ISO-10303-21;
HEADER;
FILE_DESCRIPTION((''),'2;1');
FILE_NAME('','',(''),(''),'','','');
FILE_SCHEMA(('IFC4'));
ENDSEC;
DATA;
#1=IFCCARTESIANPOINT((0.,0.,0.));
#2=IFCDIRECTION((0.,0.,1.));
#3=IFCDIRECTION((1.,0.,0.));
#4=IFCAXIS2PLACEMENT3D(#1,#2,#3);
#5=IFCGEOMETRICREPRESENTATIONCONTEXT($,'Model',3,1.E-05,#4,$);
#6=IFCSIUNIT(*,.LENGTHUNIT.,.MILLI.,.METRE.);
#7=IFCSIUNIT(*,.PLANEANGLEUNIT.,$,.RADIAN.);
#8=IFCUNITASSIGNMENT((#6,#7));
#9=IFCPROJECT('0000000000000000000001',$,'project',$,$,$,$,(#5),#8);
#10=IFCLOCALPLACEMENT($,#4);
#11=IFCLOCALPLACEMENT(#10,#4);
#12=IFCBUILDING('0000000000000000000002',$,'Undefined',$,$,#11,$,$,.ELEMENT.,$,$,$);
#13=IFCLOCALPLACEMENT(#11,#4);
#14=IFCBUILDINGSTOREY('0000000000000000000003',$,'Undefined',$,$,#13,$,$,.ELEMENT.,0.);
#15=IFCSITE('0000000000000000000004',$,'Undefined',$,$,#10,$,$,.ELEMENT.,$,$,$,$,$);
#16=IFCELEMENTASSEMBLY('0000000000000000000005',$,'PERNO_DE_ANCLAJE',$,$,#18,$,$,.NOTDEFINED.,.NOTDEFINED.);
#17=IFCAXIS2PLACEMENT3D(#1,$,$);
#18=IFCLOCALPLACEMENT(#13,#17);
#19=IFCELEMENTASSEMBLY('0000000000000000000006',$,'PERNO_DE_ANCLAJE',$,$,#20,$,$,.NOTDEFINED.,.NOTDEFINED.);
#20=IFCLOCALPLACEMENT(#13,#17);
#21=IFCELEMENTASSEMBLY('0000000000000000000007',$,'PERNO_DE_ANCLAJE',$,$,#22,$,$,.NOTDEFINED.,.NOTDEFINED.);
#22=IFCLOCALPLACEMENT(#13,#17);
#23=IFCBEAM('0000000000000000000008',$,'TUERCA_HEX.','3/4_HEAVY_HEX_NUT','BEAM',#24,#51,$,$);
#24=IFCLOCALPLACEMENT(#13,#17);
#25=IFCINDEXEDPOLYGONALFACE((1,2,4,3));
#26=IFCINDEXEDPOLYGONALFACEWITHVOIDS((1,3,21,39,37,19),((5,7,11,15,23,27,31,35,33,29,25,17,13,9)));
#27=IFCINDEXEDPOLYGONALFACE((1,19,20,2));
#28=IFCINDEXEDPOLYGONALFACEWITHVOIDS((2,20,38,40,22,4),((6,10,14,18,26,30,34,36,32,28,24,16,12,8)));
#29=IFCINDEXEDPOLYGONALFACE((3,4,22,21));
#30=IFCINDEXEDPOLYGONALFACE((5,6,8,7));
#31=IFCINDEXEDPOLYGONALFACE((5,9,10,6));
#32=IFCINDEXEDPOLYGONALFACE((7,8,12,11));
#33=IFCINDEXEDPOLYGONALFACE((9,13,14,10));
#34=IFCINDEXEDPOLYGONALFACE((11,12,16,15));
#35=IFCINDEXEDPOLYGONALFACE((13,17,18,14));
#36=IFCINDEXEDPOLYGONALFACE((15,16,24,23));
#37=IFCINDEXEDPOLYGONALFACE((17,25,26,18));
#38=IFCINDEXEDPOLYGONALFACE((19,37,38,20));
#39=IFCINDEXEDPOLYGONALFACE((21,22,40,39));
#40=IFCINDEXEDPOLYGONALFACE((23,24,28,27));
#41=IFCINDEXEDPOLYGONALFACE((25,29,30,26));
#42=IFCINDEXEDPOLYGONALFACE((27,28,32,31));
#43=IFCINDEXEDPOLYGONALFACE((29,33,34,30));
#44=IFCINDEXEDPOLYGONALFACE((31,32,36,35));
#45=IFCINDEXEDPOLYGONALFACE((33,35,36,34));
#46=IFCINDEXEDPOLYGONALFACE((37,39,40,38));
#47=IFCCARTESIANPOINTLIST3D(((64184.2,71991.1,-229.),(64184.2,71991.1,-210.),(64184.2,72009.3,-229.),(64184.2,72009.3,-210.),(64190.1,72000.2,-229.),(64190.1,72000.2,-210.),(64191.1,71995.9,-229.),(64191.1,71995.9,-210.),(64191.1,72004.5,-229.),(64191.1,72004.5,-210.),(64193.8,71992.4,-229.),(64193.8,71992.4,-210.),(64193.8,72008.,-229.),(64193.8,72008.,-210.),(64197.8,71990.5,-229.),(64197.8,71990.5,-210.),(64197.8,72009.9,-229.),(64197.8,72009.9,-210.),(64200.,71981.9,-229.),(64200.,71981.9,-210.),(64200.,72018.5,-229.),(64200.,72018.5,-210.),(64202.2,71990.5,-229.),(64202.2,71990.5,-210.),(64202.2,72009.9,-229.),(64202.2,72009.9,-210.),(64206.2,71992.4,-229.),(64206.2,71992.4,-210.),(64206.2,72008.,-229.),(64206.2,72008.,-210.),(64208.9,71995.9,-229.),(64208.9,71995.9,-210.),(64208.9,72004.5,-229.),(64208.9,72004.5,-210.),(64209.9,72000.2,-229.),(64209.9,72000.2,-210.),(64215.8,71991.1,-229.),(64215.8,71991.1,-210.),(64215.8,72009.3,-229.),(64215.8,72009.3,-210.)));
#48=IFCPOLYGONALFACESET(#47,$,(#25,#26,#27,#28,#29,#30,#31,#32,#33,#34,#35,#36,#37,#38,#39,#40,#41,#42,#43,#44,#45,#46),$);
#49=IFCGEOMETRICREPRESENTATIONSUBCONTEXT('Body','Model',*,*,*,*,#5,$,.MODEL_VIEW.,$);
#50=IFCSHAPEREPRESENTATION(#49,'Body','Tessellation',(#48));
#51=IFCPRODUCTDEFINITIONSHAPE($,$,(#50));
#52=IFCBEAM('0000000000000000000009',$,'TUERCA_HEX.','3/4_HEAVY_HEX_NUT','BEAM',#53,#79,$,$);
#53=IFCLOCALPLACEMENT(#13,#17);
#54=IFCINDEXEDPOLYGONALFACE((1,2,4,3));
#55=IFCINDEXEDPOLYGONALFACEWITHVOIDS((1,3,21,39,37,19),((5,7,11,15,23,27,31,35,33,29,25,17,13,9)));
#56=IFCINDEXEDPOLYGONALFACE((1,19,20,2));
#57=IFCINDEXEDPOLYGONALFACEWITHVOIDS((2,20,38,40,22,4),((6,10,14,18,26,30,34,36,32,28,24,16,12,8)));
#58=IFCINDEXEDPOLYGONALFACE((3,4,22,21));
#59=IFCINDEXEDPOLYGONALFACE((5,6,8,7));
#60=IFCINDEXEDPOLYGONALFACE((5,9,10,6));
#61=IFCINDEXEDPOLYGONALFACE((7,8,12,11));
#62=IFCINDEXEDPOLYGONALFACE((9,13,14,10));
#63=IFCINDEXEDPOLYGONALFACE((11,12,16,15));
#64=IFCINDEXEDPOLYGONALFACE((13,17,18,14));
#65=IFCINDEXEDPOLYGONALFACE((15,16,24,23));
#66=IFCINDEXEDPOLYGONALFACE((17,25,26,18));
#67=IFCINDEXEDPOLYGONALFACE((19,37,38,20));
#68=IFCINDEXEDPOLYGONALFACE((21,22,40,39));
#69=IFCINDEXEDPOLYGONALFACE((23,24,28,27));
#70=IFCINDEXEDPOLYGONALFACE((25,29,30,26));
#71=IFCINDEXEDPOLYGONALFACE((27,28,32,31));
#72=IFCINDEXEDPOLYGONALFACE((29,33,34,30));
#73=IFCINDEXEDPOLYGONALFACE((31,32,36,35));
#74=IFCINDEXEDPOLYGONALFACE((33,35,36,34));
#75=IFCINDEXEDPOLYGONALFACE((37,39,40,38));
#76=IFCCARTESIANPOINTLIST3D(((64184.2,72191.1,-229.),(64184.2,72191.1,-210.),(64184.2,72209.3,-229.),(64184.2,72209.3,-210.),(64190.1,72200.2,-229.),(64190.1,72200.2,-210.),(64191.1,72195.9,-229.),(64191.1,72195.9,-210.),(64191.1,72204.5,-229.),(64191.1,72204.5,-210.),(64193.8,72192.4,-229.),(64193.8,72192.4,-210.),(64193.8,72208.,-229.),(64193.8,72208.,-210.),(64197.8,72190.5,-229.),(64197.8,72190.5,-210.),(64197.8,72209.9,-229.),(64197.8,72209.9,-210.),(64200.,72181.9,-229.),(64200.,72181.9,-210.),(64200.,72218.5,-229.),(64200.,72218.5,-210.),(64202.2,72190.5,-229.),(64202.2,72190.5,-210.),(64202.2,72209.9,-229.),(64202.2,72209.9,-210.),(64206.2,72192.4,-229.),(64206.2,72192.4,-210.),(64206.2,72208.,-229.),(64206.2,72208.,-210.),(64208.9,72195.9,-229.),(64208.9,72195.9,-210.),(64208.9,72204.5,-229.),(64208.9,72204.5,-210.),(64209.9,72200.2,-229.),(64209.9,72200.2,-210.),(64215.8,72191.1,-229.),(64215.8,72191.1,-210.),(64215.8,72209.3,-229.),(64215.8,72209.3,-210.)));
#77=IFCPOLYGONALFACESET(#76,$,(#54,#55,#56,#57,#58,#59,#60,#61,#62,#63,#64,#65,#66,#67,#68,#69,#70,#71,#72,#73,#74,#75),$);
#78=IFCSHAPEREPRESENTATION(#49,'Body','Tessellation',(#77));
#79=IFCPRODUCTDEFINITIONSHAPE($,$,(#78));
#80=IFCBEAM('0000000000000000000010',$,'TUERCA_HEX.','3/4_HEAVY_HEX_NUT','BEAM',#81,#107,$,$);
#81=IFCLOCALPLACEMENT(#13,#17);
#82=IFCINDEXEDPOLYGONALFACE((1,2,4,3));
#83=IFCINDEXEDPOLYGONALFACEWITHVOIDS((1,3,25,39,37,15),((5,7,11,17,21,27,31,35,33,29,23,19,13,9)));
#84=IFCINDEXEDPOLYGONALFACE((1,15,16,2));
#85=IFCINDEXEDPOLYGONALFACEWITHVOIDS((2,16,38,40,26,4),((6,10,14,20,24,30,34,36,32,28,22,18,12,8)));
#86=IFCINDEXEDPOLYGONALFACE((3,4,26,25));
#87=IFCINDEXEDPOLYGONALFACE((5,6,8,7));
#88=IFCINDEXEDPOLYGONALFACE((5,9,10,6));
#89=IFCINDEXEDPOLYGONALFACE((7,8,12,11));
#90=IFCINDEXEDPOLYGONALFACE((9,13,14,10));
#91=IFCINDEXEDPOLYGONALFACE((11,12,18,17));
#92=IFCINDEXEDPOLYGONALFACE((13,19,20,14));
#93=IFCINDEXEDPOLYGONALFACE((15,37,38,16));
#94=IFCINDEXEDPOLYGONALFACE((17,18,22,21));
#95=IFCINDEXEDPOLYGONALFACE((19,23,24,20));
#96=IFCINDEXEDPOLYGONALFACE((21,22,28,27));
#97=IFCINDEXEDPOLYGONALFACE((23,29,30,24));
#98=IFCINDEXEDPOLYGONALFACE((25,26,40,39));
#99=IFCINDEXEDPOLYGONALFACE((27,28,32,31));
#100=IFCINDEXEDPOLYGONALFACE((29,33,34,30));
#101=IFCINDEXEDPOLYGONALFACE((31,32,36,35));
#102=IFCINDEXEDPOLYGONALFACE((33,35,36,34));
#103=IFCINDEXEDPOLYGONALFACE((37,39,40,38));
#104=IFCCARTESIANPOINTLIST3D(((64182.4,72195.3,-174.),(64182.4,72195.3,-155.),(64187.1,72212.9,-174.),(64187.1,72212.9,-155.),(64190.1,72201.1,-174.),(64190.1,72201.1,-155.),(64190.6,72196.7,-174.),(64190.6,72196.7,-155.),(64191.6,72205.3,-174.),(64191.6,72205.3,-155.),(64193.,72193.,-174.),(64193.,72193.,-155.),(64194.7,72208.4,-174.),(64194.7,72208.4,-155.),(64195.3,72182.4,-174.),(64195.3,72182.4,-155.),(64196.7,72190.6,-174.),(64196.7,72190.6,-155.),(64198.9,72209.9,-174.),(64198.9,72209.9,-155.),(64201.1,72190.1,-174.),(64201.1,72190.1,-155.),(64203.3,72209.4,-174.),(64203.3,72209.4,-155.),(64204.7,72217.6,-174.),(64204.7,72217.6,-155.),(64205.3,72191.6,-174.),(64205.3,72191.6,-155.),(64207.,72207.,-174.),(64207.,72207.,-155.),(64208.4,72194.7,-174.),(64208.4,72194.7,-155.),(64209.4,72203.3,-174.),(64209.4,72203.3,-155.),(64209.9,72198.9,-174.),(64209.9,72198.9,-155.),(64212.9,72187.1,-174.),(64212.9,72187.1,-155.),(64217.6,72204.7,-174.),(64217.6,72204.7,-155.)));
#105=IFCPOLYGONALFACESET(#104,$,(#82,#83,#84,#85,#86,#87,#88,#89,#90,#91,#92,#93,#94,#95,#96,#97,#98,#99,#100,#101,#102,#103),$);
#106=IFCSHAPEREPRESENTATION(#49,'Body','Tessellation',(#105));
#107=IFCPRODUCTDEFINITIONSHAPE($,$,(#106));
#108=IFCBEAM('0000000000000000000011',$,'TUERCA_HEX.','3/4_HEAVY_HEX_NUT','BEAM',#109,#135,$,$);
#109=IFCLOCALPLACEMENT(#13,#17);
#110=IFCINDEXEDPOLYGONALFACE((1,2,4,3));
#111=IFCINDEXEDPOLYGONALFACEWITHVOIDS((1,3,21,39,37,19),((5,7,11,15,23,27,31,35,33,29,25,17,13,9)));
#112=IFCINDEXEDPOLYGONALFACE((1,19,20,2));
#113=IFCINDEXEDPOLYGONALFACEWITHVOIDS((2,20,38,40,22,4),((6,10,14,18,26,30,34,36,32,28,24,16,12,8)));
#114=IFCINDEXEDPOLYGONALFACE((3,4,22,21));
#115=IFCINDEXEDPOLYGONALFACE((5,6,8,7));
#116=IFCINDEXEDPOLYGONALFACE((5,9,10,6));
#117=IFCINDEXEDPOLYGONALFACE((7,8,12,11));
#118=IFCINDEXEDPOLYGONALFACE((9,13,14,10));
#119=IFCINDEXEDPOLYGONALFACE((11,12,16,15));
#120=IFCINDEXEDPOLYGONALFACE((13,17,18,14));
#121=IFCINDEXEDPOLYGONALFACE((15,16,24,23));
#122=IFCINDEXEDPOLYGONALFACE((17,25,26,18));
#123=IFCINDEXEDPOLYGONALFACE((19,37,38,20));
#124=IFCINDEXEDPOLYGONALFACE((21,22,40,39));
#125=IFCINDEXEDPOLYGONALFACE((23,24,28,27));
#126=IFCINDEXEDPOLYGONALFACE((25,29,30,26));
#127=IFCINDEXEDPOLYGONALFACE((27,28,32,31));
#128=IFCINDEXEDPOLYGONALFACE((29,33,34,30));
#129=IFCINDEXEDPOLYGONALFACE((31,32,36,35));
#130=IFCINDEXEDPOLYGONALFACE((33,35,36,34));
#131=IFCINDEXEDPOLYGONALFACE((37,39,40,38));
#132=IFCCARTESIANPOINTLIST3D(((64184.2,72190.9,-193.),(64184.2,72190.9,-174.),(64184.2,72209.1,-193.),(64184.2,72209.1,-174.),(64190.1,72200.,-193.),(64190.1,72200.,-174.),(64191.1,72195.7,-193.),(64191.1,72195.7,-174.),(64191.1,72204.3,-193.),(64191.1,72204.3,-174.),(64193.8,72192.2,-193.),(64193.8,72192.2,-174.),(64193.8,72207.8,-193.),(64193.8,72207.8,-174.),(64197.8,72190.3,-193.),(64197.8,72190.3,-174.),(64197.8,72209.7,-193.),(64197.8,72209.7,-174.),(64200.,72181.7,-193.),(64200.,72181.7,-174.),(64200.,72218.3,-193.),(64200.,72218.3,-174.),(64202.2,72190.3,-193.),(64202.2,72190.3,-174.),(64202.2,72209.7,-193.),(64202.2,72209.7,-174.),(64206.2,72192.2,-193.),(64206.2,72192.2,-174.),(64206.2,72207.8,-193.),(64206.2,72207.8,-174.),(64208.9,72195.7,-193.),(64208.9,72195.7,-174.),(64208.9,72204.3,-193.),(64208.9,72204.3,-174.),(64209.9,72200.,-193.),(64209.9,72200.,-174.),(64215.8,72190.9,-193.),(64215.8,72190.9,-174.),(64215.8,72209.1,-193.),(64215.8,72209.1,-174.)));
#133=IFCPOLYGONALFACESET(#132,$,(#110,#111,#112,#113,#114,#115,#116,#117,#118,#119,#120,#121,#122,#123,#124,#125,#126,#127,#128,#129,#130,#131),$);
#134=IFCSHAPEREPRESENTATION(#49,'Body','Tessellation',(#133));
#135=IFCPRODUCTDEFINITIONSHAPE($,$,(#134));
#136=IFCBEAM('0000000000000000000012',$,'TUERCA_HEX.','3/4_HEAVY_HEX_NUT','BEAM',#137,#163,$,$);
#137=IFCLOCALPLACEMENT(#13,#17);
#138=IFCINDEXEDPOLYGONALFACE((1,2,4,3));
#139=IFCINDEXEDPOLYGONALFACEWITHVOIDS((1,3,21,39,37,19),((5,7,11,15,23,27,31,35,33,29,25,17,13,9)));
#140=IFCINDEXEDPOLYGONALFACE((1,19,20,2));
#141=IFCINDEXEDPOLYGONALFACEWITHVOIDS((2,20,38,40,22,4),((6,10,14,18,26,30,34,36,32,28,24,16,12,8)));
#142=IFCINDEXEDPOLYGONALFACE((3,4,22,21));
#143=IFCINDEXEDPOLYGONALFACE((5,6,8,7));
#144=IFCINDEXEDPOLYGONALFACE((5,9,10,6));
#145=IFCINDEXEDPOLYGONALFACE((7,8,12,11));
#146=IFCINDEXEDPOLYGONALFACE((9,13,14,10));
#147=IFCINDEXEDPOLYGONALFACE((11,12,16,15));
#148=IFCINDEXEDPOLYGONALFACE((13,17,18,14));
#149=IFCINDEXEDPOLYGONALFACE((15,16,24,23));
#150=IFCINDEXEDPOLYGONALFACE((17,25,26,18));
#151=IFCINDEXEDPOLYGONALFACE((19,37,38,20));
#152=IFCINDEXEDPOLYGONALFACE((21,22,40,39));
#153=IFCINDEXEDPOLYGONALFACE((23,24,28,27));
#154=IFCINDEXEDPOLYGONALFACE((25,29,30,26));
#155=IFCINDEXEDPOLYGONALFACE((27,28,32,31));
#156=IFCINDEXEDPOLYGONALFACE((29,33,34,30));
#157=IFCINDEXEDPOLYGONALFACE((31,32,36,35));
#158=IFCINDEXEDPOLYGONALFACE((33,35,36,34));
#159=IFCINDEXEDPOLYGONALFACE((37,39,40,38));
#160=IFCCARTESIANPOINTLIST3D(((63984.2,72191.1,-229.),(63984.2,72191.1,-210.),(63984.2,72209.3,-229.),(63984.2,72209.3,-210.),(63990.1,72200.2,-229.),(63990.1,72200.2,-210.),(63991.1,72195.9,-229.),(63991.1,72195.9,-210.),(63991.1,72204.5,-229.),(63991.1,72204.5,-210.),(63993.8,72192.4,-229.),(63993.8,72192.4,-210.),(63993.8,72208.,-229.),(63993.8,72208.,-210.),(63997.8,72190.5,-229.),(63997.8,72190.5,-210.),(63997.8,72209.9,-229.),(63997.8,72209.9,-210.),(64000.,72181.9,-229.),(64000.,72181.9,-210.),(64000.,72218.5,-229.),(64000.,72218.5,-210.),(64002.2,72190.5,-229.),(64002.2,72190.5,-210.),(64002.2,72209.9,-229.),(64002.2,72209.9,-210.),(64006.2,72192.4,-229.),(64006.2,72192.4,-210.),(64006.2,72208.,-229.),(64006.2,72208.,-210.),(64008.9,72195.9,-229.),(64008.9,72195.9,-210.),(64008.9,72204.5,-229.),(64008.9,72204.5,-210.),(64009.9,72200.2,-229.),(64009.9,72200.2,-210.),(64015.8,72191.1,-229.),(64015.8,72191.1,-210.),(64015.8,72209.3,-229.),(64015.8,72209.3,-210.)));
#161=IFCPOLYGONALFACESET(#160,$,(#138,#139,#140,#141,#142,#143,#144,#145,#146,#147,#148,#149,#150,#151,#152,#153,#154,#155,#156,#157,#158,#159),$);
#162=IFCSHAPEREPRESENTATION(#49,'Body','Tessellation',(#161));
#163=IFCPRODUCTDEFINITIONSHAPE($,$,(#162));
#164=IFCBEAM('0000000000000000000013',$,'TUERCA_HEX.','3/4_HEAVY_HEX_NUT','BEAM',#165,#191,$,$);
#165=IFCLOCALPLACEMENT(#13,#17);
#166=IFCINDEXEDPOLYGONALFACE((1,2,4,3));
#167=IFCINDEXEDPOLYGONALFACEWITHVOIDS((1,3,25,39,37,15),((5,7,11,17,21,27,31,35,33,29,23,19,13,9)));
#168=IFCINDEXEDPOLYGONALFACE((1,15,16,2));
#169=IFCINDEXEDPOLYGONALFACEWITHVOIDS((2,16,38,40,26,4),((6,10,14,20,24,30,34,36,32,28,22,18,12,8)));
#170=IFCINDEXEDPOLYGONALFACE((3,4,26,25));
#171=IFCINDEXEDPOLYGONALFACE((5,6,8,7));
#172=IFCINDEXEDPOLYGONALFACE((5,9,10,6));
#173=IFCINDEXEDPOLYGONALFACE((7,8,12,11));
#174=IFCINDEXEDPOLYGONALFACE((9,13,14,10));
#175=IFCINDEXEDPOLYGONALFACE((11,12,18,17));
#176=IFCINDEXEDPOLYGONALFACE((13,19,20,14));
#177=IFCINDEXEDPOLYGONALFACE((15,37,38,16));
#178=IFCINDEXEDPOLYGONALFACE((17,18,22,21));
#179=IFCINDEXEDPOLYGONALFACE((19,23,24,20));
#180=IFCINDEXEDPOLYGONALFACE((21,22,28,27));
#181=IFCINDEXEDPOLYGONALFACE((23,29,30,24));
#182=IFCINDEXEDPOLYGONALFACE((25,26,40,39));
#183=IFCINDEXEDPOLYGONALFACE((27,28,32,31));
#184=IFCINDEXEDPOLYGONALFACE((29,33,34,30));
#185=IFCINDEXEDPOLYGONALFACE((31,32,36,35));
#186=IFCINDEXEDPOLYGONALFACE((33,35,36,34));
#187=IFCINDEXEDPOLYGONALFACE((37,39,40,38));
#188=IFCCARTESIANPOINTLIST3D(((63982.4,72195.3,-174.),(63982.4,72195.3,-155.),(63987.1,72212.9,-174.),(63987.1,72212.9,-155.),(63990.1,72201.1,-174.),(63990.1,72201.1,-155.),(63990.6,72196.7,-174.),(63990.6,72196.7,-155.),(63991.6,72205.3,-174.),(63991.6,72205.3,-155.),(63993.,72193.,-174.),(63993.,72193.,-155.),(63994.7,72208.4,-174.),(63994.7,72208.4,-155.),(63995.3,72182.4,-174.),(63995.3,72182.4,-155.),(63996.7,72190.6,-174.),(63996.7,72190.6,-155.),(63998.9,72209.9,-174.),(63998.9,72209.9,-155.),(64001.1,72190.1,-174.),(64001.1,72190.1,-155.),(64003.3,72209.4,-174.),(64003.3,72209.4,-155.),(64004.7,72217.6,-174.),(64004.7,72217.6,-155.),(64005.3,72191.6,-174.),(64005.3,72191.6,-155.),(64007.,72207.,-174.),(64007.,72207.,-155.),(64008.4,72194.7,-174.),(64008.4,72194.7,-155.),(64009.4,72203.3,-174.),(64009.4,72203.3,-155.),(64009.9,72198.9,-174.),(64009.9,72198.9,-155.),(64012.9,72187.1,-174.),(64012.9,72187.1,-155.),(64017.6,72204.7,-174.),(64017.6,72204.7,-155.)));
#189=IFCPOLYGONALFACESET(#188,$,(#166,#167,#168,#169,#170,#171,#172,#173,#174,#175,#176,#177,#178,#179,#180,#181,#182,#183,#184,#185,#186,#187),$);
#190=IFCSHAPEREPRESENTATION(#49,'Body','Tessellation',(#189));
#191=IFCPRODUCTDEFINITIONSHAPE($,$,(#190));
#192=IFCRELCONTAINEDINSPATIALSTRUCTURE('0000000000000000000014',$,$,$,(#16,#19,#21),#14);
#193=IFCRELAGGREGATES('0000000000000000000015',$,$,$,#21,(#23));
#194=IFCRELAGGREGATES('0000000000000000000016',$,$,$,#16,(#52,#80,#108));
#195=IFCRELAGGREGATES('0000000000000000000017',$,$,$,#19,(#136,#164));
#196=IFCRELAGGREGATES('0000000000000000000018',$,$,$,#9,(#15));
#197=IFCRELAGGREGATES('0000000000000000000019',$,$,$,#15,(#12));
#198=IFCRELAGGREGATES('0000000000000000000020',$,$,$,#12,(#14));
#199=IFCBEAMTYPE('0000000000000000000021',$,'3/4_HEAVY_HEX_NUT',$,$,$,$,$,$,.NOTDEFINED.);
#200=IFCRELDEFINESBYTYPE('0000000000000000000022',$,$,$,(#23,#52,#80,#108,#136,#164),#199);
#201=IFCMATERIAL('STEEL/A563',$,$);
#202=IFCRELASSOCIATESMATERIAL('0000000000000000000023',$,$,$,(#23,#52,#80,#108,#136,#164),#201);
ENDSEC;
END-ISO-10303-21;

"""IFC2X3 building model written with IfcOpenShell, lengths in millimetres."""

from ifc_helpers import new_model, si_unit, frame, origin_with_axes, place, context, subcontext, project, spatial, polyline, outline, extrude, material, type_object, element, aggregate, save


model = new_model("IFC2X3")

# Units and contexts
model_context = context("Model", 3, precision=1e-05, world=origin_with_axes())
body_context = subcontext(model_context, "Body", "Model", "MODEL_VIEW")
ifc_project = project(units=[si_unit("LENGTHUNIT", "METRE", prefix="MILLI"), si_unit("PLANEANGLEUNIT", "RADIAN")], contexts=[model_context])

# Site, building, storey
site_placement = place(None, origin_with_axes())
site = spatial("IfcSite", under=ifc_project, at=site_placement, Name="Undefined", CompositionType="ELEMENT")
building_placement = place(site_placement, origin_with_axes())
building = spatial("IfcBuilding", under=site, at=building_placement, Name="Undefined", CompositionType="ELEMENT")
storey_placement = place(building_placement, origin_with_axes())
storey = spatial("IfcBuildingStorey", under=building, at=storey_placement, Name="Undefined", CompositionType="ELEMENT", Elevation=0.0)

# Element assemblies, beam
assembly_1_placement = place(storey_placement, origin_with_axes())
assembly_1 = element("IfcElementAssembly", 1, at=assembly_1_placement, inside=storey, Name="PERNO_DE_ANCLAJE", AssemblyPlace="NOTDEFINED", PredefinedType="NOTDEFINED")
ifc_material_1 = material(Name="STEEL/A563")
assembly_2_placement = place(storey_placement, origin_with_axes())
assembly_2 = element("IfcElementAssembly", 2, at=assembly_2_placement, inside=storey, Name="PERNO_DE_ANCLAJE", AssemblyPlace="NOTDEFINED", PredefinedType="NOTDEFINED")
assembly_3_placement = place(storey_placement, origin_with_axes())
assembly_3 = element("IfcElementAssembly", 3, at=assembly_3_placement, inside=storey, Name="PERNO_DE_ANCLAJE", AssemblyPlace="NOTDEFINED", PredefinedType="NOTDEFINED")
beam_type_1 = type_object("IfcBeamType", Name="3/4_HEAVY_HEX_NUT", PredefinedType="NOTDEFINED")
beam_1_placement = place(assembly_3_placement, frame((64200.0, 72000.2, -210.0), z_axis=(1.0, 0.0, 0.0), x_axis=(0.0, 0.0, -1.0)))
beam_1 = element("IfcBeam", 4, at=beam_1_placement, type_object=beam_type_1, material=ifc_material_1, Name="TUERCA_HEX.", Description="3/4_HEAVY_HEX_NUT", ObjectType="BEAM", context=body_context, shape_type="SweptSolid", body=[
    extrude(outline(polyline([(-9.1, -15.8), (-18.3, 0.0), (-9.1, 15.8), (9.1, 15.8), (18.3, 0.0), (9.1, -15.8), (-9.1, -15.8)]), holes=[polyline([(7.8, 6.2), (4.3, 8.9), (0.0, 9.9), (-4.3, 8.9), (-7.8, 6.2), (-9.7, 2.2), (-9.7, -2.2), (-7.8, -6.2), (-4.3, -8.9), (0.0, -9.9), (4.3, -8.9), (7.8, -6.2), (9.7, -2.2), (9.7, 2.2), (7.8, 6.2)])]), frame((19.0, 0.0, 0.0), z_axis=(-1.0, 0.0, 0.0), x_axis=(0.0, -1.0, 0.0)), (0.0, 0.0, 1.0), 19.0),
])
aggregate(assembly_3, [beam_1])

# Beams
beam_2_placement = place(assembly_1_placement, frame((64200.0, 72200.2, -210.0), z_axis=(1.0, 0.0, 0.0), x_axis=(0.0, 0.0, -1.0)))
beam_2 = element("IfcBeam", 5, at=beam_2_placement, type_object=beam_type_1, material=ifc_material_1, Name="TUERCA_HEX.", Description="3/4_HEAVY_HEX_NUT", ObjectType="BEAM", context=body_context, shape_type="SweptSolid", body=[
    extrude(outline(polyline([(-9.1, -15.8), (-18.3, 0.0), (-9.1, 15.8), (9.1, 15.8), (18.3, 0.0), (9.1, -15.8), (-9.1, -15.8)]), holes=[polyline([(7.8, 6.2), (4.3, 8.9), (0.0, 9.9), (-4.3, 8.9), (-7.8, 6.2), (-9.7, 2.2), (-9.7, -2.2), (-7.8, -6.2), (-4.3, -8.9), (0.0, -9.9), (4.3, -8.9), (7.8, -6.2), (9.7, -2.2), (9.7, 2.2), (7.8, 6.2)])]), frame((19.0, 0.0, 0.0), z_axis=(-1.0, 0.0, 0.0), x_axis=(0.0, -1.0, 0.0)), (0.0, 0.0, 1.0), 19.0),
])
beam_3_placement = place(assembly_1_placement, frame((64200.0, 72200.0, -155.0), z_axis=(0.707107, 0.707107, 0.0), x_axis=(0.0, 0.0, -1.0)))
beam_3 = element("IfcBeam", 6, at=beam_3_placement, type_object=beam_type_1, material=ifc_material_1, Name="TUERCA_HEX.", Description="3/4_HEAVY_HEX_NUT", ObjectType="BEAM", context=body_context, shape_type="SweptSolid", body=[
    extrude(outline(polyline([(-9.1, -15.8), (-18.3, 0.0), (-9.1, 15.8), (9.1, 15.8), (18.3, 0.0), (9.1, -15.8), (-9.1, -15.8)]), holes=[polyline([(7.8, 6.2), (4.3, 8.9), (0.0, 9.9), (-4.3, 8.9), (-7.8, 6.2), (-9.7, 2.2), (-9.7, -2.2), (-7.8, -6.2), (-4.3, -8.9), (0.0, -9.9), (4.3, -8.9), (7.8, -6.2), (9.7, -2.2), (9.7, 2.2), (7.8, 6.2)])]), frame((19.0, 0.0, 0.0), z_axis=(-1.0, 0.0, 0.0), x_axis=(0.0, -1.0, 0.0)), (0.0, 0.0, 1.0), 19.0),
])
beam_4_placement = place(assembly_1_placement, frame((64200.0, 72200.0, -174.0), z_axis=(1.0, 0.0, 0.0), x_axis=(0.0, 0.0, -1.0)))
beam_4 = element("IfcBeam", 7, at=beam_4_placement, type_object=beam_type_1, material=ifc_material_1, Name="TUERCA_HEX.", Description="3/4_HEAVY_HEX_NUT", ObjectType="BEAM", context=body_context, shape_type="SweptSolid", body=[
    extrude(outline(polyline([(-9.1, -15.8), (-18.3, 0.0), (-9.1, 15.8), (9.1, 15.8), (18.3, 0.0), (9.1, -15.8), (-9.1, -15.8)]), holes=[polyline([(7.8, 6.2), (4.3, 8.9), (0.0, 9.9), (-4.3, 8.9), (-7.8, 6.2), (-9.7, 2.2), (-9.7, -2.2), (-7.8, -6.2), (-4.3, -8.9), (0.0, -9.9), (4.3, -8.9), (7.8, -6.2), (9.7, -2.2), (9.7, 2.2), (7.8, 6.2)])]), frame((19.0, 0.0, 0.0), z_axis=(-1.0, 0.0, 0.0), x_axis=(0.0, -1.0, 0.0)), (0.0, 0.0, 1.0), 19.0),
])
aggregate(assembly_1, [beam_2, beam_3, beam_4])
beam_5_placement = place(assembly_2_placement, frame((64000.0, 72200.2, -210.0), z_axis=(1.0, 0.0, 0.0), x_axis=(0.0, 0.0, -1.0)))
beam_5 = element("IfcBeam", 8, at=beam_5_placement, type_object=beam_type_1, material=ifc_material_1, Name="TUERCA_HEX.", Description="3/4_HEAVY_HEX_NUT", ObjectType="BEAM", context=body_context, shape_type="SweptSolid", body=[
    extrude(outline(polyline([(-9.1, -15.8), (-18.3, 0.0), (-9.1, 15.8), (9.1, 15.8), (18.3, 0.0), (9.1, -15.8), (-9.1, -15.8)]), holes=[polyline([(7.8, 6.2), (4.3, 8.9), (0.0, 9.9), (-4.3, 8.9), (-7.8, 6.2), (-9.7, 2.2), (-9.7, -2.2), (-7.8, -6.2), (-4.3, -8.9), (0.0, -9.9), (4.3, -8.9), (7.8, -6.2), (9.7, -2.2), (9.7, 2.2), (7.8, 6.2)])]), frame((19.0, 0.0, 0.0), z_axis=(-1.0, 0.0, 0.0), x_axis=(0.0, -1.0, 0.0)), (0.0, 0.0, 1.0), 19.0),
])
beam_6_placement = place(assembly_2_placement, frame((64000.0, 72200.0, -155.0), z_axis=(0.707107, 0.707107, 0.0), x_axis=(0.0, 0.0, -1.0)))
beam_6 = element("IfcBeam", 9, at=beam_6_placement, type_object=beam_type_1, material=ifc_material_1, Name="TUERCA_HEX.", Description="3/4_HEAVY_HEX_NUT", ObjectType="BEAM", context=body_context, shape_type="SweptSolid", body=[
    extrude(outline(polyline([(-9.1, -15.8), (-18.3, 0.0), (-9.1, 15.8), (9.1, 15.8), (18.3, 0.0), (9.1, -15.8), (-9.1, -15.8)]), holes=[polyline([(7.8, 6.2), (4.3, 8.9), (0.0, 9.9), (-4.3, 8.9), (-7.8, 6.2), (-9.7, 2.2), (-9.7, -2.2), (-7.8, -6.2), (-4.3, -8.9), (0.0, -9.9), (4.3, -8.9), (7.8, -6.2), (9.7, -2.2), (9.7, 2.2), (7.8, 6.2)])]), frame((19.0, 0.0, 0.0), z_axis=(-1.0, 0.0, 0.0), x_axis=(0.0, -1.0, 0.0)), (0.0, 0.0, 1.0), 19.0),
])
aggregate(assembly_2, [beam_5, beam_6])

save(model, "model.ifc")
